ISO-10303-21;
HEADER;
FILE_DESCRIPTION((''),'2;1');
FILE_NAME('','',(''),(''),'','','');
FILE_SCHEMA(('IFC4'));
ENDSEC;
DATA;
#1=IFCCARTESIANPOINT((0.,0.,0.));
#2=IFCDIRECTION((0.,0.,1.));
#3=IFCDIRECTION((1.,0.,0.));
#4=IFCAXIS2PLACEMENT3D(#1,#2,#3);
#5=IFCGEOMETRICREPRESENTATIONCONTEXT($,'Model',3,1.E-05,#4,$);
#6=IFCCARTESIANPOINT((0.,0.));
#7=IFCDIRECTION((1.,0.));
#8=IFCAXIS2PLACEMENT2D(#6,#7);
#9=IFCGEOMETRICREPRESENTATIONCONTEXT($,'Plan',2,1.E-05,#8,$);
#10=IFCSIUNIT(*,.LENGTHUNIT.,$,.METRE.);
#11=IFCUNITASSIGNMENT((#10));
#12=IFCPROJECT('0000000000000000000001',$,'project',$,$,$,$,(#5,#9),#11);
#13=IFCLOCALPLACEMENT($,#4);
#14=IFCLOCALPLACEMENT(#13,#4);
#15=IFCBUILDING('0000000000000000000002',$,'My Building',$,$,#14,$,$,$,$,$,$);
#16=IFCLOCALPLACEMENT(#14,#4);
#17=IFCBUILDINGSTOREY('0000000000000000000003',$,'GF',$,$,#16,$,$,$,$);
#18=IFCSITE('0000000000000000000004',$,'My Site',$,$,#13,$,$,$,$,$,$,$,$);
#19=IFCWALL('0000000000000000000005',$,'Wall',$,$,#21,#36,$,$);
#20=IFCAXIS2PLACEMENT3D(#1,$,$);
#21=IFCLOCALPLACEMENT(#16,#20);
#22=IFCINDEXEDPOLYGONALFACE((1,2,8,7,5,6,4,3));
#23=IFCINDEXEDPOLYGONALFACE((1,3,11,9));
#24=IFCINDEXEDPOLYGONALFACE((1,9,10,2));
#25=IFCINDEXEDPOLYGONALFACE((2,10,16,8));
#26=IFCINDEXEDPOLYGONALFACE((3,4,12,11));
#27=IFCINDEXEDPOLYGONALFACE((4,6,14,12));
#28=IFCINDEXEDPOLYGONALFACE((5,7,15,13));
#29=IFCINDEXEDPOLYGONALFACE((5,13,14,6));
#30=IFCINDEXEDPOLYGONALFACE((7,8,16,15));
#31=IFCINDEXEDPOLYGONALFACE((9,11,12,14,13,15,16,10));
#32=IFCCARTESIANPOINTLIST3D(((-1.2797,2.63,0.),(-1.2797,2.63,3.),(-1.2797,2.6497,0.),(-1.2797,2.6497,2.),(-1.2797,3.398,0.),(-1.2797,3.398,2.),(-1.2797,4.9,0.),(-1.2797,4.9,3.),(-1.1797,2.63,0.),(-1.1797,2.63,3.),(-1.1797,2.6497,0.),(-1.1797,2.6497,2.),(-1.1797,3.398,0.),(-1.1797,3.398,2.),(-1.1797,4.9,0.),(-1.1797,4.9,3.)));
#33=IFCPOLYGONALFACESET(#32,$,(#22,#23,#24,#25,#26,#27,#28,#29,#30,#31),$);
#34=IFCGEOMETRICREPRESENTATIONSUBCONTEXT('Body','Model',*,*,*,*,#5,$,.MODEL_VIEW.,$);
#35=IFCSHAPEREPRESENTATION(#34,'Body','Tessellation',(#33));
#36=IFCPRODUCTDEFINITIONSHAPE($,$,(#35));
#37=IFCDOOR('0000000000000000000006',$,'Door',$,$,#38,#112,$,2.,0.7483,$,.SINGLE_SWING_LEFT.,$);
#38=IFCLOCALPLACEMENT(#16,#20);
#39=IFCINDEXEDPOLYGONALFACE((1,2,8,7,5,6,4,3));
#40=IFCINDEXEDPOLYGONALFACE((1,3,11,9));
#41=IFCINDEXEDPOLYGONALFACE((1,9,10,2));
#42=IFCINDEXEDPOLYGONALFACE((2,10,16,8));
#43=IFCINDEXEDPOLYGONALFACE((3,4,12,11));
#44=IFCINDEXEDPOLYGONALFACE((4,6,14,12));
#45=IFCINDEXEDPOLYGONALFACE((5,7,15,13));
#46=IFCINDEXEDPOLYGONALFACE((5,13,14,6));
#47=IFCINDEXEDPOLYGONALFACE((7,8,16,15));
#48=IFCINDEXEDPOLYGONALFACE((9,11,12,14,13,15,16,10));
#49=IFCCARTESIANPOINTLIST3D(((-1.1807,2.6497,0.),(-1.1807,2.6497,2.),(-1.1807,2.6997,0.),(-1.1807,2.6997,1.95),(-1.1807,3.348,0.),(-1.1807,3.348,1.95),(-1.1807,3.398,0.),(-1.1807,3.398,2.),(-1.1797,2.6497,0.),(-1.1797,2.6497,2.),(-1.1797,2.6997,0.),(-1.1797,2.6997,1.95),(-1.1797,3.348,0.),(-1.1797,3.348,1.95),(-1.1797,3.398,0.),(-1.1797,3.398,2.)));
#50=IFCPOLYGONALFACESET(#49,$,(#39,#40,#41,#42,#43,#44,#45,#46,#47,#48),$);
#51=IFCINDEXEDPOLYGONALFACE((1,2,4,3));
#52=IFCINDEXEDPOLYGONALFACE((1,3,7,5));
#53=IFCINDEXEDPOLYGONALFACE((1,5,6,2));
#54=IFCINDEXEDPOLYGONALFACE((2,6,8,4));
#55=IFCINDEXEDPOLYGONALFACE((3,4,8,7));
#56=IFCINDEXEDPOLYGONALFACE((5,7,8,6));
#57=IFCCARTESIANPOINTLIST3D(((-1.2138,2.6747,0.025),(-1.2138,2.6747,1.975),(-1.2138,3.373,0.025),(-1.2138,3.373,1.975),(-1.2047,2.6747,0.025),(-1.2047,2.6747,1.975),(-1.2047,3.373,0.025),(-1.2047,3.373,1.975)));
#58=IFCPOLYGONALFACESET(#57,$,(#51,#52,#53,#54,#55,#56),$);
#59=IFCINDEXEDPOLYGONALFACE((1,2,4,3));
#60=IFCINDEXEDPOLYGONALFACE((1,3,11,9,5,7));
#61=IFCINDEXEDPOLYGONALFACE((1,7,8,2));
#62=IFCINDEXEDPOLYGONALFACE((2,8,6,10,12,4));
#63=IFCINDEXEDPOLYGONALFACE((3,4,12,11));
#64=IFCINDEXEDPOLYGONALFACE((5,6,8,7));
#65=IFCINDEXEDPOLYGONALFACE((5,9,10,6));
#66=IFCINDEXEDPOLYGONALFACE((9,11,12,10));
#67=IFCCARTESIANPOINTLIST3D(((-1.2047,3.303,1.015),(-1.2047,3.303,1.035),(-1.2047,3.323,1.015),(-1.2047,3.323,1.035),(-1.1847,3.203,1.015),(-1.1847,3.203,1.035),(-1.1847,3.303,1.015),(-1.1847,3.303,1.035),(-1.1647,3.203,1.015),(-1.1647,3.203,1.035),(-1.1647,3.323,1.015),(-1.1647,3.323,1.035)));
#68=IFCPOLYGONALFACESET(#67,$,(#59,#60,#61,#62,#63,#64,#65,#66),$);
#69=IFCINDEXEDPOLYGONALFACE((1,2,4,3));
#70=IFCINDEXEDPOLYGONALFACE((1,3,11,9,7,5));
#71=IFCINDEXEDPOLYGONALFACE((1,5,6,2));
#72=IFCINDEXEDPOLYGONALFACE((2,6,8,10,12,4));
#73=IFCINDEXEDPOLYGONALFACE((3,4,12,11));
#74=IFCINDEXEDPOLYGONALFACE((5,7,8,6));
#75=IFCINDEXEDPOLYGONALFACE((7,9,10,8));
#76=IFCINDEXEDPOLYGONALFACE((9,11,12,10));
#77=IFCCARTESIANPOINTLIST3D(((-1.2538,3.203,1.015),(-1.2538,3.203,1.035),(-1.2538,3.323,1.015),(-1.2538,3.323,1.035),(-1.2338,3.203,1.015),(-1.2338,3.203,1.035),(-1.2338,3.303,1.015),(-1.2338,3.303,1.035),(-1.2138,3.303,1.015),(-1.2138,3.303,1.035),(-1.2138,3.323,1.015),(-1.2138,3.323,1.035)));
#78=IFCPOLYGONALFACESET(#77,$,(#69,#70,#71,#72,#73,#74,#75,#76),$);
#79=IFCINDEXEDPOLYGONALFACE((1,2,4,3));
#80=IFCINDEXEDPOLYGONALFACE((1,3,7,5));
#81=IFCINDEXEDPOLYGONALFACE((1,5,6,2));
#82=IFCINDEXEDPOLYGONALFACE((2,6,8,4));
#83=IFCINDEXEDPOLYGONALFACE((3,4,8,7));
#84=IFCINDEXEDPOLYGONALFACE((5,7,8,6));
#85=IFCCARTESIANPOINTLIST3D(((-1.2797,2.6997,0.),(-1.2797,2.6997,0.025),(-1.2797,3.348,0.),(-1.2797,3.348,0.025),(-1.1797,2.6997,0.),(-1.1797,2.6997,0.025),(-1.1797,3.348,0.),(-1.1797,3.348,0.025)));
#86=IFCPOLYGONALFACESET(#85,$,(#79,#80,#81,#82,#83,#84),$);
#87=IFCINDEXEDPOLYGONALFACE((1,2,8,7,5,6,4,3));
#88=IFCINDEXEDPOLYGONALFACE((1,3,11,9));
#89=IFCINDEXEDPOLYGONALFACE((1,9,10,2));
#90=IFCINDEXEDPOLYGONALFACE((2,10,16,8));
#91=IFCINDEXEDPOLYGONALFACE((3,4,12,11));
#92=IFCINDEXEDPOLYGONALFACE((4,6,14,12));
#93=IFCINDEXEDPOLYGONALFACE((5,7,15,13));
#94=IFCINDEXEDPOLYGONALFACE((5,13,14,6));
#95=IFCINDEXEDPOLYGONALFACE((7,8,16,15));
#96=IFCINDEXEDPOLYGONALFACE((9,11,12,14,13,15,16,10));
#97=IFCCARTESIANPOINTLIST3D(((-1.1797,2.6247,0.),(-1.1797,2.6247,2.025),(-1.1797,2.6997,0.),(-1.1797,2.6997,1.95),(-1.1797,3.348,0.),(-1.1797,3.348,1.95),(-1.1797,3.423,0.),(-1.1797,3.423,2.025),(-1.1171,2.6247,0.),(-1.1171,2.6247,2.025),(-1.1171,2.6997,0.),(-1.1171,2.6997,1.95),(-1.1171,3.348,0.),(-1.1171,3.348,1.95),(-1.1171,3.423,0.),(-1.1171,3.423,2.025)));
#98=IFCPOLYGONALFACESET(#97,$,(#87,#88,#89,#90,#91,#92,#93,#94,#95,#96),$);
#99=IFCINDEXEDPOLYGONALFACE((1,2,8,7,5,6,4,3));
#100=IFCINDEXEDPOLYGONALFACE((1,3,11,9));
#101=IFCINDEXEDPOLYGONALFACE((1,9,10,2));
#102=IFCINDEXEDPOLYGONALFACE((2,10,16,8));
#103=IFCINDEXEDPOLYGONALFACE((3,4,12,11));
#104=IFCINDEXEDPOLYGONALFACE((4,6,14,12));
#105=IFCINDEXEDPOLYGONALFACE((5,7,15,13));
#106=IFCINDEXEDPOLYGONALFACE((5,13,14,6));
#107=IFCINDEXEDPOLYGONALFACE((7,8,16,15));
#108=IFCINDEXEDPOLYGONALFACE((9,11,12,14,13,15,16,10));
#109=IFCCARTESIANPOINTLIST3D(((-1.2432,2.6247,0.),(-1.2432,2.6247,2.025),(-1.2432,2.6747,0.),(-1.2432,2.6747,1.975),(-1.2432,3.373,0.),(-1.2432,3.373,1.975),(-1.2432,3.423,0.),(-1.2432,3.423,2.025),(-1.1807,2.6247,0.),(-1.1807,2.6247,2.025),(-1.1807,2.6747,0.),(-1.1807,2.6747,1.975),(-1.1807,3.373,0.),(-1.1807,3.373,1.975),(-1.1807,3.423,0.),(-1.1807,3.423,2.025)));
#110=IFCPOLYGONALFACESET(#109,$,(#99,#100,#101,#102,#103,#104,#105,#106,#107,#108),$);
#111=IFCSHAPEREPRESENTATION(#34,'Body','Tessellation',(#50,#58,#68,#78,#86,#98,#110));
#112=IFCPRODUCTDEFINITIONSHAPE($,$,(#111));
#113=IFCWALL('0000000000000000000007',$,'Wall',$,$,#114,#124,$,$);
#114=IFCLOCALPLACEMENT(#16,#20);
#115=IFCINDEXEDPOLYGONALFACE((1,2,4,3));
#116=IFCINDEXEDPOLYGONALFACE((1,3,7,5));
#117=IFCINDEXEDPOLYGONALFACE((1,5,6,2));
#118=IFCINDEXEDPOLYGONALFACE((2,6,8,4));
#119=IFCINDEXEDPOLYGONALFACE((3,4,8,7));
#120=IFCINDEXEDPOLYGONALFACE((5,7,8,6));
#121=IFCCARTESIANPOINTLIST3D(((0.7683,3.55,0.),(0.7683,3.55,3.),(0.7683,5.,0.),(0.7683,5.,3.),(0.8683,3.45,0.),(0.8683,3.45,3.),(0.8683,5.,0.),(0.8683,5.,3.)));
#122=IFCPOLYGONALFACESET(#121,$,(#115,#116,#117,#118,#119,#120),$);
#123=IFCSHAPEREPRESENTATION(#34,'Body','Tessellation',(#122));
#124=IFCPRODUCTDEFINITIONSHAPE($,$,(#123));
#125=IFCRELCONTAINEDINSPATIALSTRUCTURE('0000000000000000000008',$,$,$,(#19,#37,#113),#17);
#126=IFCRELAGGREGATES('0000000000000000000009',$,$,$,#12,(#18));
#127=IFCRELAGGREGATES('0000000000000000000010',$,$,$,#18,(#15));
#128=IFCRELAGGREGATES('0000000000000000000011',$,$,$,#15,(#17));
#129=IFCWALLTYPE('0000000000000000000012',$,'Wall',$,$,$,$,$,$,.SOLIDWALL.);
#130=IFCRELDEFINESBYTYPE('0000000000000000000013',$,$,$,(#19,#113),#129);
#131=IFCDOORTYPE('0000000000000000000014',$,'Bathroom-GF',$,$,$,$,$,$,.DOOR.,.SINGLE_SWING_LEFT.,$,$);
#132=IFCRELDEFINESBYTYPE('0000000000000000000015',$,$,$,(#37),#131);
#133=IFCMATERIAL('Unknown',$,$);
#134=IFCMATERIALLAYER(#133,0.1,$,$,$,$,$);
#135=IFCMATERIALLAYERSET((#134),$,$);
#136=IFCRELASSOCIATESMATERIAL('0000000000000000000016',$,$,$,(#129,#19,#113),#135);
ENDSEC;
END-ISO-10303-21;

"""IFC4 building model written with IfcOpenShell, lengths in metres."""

from ifc_helpers import new_model, entity, si_unit, frame, origin_with_axes, origin_2d_with_axis, place, context, subcontext, project, spatial, line, indexed_curve, outline, extrude, shape, source, transform, mapped, material, layer, layer_set, layer_usage, type_object, type_shapes, element, fill, save


model = new_model("IFC4")

# Units and contexts
model_context = context("Model", 3, precision=1e-05, world=origin_with_axes())
plan_context = context("Plan", 2, precision=1e-05, world=origin_2d_with_axis())
body_context_1 = subcontext(model_context, "Body", "Model", "MODEL_VIEW")
body_context_2 = subcontext(plan_context, "Body", "Plan", "PLAN_VIEW")
ifc_project = project(units=[si_unit("LENGTHUNIT", "METRE")], contexts=[model_context, plan_context])

# Site, building, storey
site_placement = place(None, origin_with_axes())
site = spatial("IfcSite", under=ifc_project, at=site_placement, Name="My Site")
building_placement = place(site_placement, origin_with_axes())
building = spatial("IfcBuilding", under=site, at=building_placement, Name="My Building")
storey_placement = place(building_placement, origin_with_axes())
storey = spatial("IfcBuildingStorey", under=building, at=storey_placement, Name="GF")

# Shared definitions
ifc_material = material(Name="Unknown")

# Shared definitions
ifc_layer_1 = layer(ifc_material, 0.1)
ifc_layer_set_1 = layer_set([ifc_layer_1])
wall_type = type_object("IfcWallType", Name="Wall", PredefinedType="SOLIDWALL", material=ifc_layer_set_1)

# Wall, opening, door
ifc_layer_usage_1 = layer_usage(ifc_layer_set_1, "AXIS2", "POSITIVE", 0.0)
wall_1_placement = place(storey_placement, frame((-1.1797, 2.63, 0.0), z_axis=(0.0, 0.0, 1.0), x_axis=(0.0, 1.0, 0.0)))
wall_1 = element("IfcWall", 1, at=wall_1_placement, inside=storey, type_object=wall_type, material=ifc_layer_usage_1, Name="Wall", context=body_context_1, shape_type="SweptSolid", body=[
    extrude(outline(indexed_curve([(0.0, 0.0), (0.0, 0.1), (2.27, 0.1), (2.27, 0.0)], segments=[line(1, 2, 3, 4, 1)])), origin_with_axes(), (0.0, 0.0, 1.0), 3.0),
])
shared_shape_1 = source(origin_with_axes(), body_context_1, "Body", "SweptSolid", [
    extrude(outline(indexed_curve([(0.0, 0.0), (0.7483, 0.0), (0.7483, 2.0), (0.0, 2.0)], segments=[line(1, 2, 3, 4, 1)])), frame((0.0, -0.6, 0.0), z_axis=(0.0, -1.0, 0.0), x_axis=(1.0, 0.0, 0.0)), (0.0, 0.0, -1.0), 1.2),
])
opening_1_placement = place(wall_1_placement, frame((0.0197, 0.0, 0.0), z_axis=(0.0, 0.0, 1.0), x_axis=(1.0, 0.0, 0.0)))
opening_1 = element("IfcOpeningElement", 2, at=opening_1_placement, cuts=wall_1, PredefinedType="OPENING", context=body_context_1, shape_type="MappedRepresentation", body=[
    mapped(shared_shape_1, transform((0.0, 0.0, 0.0), x_axis=(1.0, 0.0, 0.0), y_axis=(0.0, 1.0, 0.0), z_axis=(0.0, 0.0, 1.0), scale=1.0)),
])
door_type_1 = type_object("IfcDoorType", Name="Bathroom-GF", OperationType="SINGLE_SWING_LEFT", PredefinedType="DOOR")
shared_shape_2 = source(origin_with_axes(), body_context_1, "Body", "SweptSolid", [
    extrude(outline(indexed_curve([(0.0, 0.0), (0.0, 2.0), (0.7483, 2.0), (0.7483, 0.0), (0.6983, 0.0), (0.6983, 1.95), (0.05, 1.95), (0.05, 0.0)], segments=[line(1, 2, 3, 4, 5, 6, 7, 8, 1)])), frame((0.0, 0.0, 0.0), z_axis=(0.0, -1.0, 0.0), x_axis=(1.0, 0.0, 0.0)), (0.0, 0.0, -1.0), 0.001),
    extrude(outline(indexed_curve([(0.0, 0.0), (0.6983, 0.0), (0.6983, 0.0092), (0.0, 0.0092)], segments=[line(1, 2, 3, 4, 1)])), frame((0.025, 0.025, 0.025), z_axis=(0.0, 0.0, 1.0), x_axis=(1.0, 0.0, 0.0)), (0.0, 0.0, 1.0), 1.95),
    extrude(outline(indexed_curve([(0.0, 0.0), (0.0, -0.04), (-0.12, -0.04), (-0.12, -0.02), (-0.02, -0.02), (-0.02, 0.0)], segments=[line(1, 2, 3, 4, 5, 6, 1)])), frame((0.6733, 0.025, 1.015), z_axis=(0.0, 0.0, 1.0), x_axis=(1.0, 0.0, 0.0)), (0.0, 0.0, 1.0), 0.02),
    extrude(outline(indexed_curve([(0.0, 0.0), (0.0, 0.04), (-0.12, 0.04), (-0.12, 0.02), (-0.02, 0.02), (-0.02, 0.0)], segments=[line(1, 2, 3, 4, 5, 6, 1)])), frame((0.6733, 0.0342, 1.015), z_axis=(0.0, 0.0, 1.0), x_axis=(1.0, 0.0, 0.0)), (0.0, 0.0, 1.0), 0.02),
    extrude(outline(indexed_curve([(0.0, 0.0), (0.6483, 0.0), (0.6483, 0.1), (0.0, 0.1)], segments=[line(1, 2, 3, 4, 1)])), frame((0.05, 0.0, 0.0), z_axis=(0.0, 0.0, 1.0), x_axis=(1.0, 0.0, 0.0)), (0.0, 0.0, 1.0), 0.025),
    extrude(outline(indexed_curve([(0.0, 0.0), (0.0, 2.025), (0.7983, 2.025), (0.7983, 0.0), (0.7233, 0.0), (0.7233, 1.95), (0.075, 1.95), (0.075, 0.0)], segments=[line(1, 2, 3, 4, 5, 6, 7, 8, 1)])), frame((-0.025, -0.0626, 0.0), z_axis=(0.0, -1.0, 0.0), x_axis=(1.0, 0.0, 0.0)), (0.0, 0.0, -1.0), 0.0626),
    extrude(outline(indexed_curve([(0.0, 0.0), (0.0, 2.025), (0.7983, 2.025), (0.7983, 0.0), (0.7483, 0.0), (0.7483, 1.975), (0.05, 1.975), (0.05, 0.0)], segments=[line(1, 2, 3, 4, 5, 6, 7, 8, 1)])), frame((-0.025, 0.001, 0.0), z_axis=(0.0, -1.0, 0.0), x_axis=(1.0, 0.0, 0.0)), (0.0, 0.0, -1.0), 0.0626),
])
shared_shape_3 = source(origin_with_axes(), body_context_2, "Body", "Curve2D", [
    entity("IfcIndexedPolyCurve", entity("IfcCartesianPointList2D", [[0.0, 0.0], [0.05, 0.0], [0.05, 0.001], [0.0, 0.001]]), [entity("IfcLineIndex", [1, 2, 3, 4, 1])]),
    entity("IfcIndexedPolyCurve", entity("IfcCartesianPointList2D", [[0.7483, 0.0], [0.6983, 0.0], [0.6983, 0.001], [0.7483, 0.001]]), [entity("IfcLineIndex", [1, 2, 3, 4, 1])]),
    entity("IfcTrimmedCurve", entity("IfcEllipse", entity("IfcAxis2Placement2D", entity("IfcCartesianPoint", [0.0342, 0.001]), entity("IfcDirection", [1.0, 0.0])), 0.6891, 0.6983), [entity("IfcCartesianPoint", [0.7233, 0.001])], [entity("IfcCartesianPoint", [0.0342, 0.6993])], True, "CARTESIAN"),
    entity("IfcIndexedPolyCurve", entity("IfcCartesianPointList2D", [[0.025, 0.001], [0.0342, 0.001], [0.0342, 0.6993], [0.025, 0.6993]]), [entity("IfcLineIndex", [1, 2, 3, 4, 1])]),
])
type_shapes(door_type_1, [shared_shape_2, shared_shape_3])
door_1_placement = place(opening_1_placement, frame((0.0, 0.0, 0.0), z_axis=(0.0, 0.0, 1.0), x_axis=(1.0, 0.0, 0.0)))
door_1 = element("IfcDoor", 3, at=door_1_placement, inside=storey, type_object=door_type_1, Name="Door", OperationType="SINGLE_SWING_LEFT", OverallHeight=2.0, OverallWidth=0.7483, shapes=[
    shape(body_context_1, "Body", "MappedRepresentation", [mapped(shared_shape_2, transform((0.0, 0.0, 0.0), x_axis=(1.0, 0.0, 0.0), y_axis=(0.0, 1.0, 0.0), z_axis=(0.0, 0.0, 1.0), scale=1.0))]),
    shape(body_context_2, "Body", "MappedRepresentation", [mapped(shared_shape_3, transform((0.0, 0.0, 0.0), x_axis=(1.0, 0.0, 0.0), y_axis=(0.0, 1.0, 0.0), z_axis=(0.0, 0.0, 1.0), scale=1.0))]),
])
fill(opening_1, door_1)

# Wall
ifc_layer_usage_2 = layer_usage(ifc_layer_set_1, "AXIS2", "POSITIVE", 0.0)
wall_2_placement = place(storey_placement, frame((0.7683, 5.0, 0.0), z_axis=(0.0, 0.0, 1.0), x_axis=(0.0, -1.0, 0.0)))
element("IfcWall", 4, at=wall_2_placement, inside=storey, type_object=wall_type, material=ifc_layer_usage_2, Name="Wall", context=body_context_1, shape_type="SweptSolid", body=[
    extrude(outline(indexed_curve([(0.0, 0.0), (0.0, 0.1), (1.55, 0.1), (1.45, 0.0)], segments=[line(1, 2, 3, 4, 1)])), origin_with_axes(), (0.0, 0.0, 1.0), 3.0),
])

save(model, "model.ifc")
